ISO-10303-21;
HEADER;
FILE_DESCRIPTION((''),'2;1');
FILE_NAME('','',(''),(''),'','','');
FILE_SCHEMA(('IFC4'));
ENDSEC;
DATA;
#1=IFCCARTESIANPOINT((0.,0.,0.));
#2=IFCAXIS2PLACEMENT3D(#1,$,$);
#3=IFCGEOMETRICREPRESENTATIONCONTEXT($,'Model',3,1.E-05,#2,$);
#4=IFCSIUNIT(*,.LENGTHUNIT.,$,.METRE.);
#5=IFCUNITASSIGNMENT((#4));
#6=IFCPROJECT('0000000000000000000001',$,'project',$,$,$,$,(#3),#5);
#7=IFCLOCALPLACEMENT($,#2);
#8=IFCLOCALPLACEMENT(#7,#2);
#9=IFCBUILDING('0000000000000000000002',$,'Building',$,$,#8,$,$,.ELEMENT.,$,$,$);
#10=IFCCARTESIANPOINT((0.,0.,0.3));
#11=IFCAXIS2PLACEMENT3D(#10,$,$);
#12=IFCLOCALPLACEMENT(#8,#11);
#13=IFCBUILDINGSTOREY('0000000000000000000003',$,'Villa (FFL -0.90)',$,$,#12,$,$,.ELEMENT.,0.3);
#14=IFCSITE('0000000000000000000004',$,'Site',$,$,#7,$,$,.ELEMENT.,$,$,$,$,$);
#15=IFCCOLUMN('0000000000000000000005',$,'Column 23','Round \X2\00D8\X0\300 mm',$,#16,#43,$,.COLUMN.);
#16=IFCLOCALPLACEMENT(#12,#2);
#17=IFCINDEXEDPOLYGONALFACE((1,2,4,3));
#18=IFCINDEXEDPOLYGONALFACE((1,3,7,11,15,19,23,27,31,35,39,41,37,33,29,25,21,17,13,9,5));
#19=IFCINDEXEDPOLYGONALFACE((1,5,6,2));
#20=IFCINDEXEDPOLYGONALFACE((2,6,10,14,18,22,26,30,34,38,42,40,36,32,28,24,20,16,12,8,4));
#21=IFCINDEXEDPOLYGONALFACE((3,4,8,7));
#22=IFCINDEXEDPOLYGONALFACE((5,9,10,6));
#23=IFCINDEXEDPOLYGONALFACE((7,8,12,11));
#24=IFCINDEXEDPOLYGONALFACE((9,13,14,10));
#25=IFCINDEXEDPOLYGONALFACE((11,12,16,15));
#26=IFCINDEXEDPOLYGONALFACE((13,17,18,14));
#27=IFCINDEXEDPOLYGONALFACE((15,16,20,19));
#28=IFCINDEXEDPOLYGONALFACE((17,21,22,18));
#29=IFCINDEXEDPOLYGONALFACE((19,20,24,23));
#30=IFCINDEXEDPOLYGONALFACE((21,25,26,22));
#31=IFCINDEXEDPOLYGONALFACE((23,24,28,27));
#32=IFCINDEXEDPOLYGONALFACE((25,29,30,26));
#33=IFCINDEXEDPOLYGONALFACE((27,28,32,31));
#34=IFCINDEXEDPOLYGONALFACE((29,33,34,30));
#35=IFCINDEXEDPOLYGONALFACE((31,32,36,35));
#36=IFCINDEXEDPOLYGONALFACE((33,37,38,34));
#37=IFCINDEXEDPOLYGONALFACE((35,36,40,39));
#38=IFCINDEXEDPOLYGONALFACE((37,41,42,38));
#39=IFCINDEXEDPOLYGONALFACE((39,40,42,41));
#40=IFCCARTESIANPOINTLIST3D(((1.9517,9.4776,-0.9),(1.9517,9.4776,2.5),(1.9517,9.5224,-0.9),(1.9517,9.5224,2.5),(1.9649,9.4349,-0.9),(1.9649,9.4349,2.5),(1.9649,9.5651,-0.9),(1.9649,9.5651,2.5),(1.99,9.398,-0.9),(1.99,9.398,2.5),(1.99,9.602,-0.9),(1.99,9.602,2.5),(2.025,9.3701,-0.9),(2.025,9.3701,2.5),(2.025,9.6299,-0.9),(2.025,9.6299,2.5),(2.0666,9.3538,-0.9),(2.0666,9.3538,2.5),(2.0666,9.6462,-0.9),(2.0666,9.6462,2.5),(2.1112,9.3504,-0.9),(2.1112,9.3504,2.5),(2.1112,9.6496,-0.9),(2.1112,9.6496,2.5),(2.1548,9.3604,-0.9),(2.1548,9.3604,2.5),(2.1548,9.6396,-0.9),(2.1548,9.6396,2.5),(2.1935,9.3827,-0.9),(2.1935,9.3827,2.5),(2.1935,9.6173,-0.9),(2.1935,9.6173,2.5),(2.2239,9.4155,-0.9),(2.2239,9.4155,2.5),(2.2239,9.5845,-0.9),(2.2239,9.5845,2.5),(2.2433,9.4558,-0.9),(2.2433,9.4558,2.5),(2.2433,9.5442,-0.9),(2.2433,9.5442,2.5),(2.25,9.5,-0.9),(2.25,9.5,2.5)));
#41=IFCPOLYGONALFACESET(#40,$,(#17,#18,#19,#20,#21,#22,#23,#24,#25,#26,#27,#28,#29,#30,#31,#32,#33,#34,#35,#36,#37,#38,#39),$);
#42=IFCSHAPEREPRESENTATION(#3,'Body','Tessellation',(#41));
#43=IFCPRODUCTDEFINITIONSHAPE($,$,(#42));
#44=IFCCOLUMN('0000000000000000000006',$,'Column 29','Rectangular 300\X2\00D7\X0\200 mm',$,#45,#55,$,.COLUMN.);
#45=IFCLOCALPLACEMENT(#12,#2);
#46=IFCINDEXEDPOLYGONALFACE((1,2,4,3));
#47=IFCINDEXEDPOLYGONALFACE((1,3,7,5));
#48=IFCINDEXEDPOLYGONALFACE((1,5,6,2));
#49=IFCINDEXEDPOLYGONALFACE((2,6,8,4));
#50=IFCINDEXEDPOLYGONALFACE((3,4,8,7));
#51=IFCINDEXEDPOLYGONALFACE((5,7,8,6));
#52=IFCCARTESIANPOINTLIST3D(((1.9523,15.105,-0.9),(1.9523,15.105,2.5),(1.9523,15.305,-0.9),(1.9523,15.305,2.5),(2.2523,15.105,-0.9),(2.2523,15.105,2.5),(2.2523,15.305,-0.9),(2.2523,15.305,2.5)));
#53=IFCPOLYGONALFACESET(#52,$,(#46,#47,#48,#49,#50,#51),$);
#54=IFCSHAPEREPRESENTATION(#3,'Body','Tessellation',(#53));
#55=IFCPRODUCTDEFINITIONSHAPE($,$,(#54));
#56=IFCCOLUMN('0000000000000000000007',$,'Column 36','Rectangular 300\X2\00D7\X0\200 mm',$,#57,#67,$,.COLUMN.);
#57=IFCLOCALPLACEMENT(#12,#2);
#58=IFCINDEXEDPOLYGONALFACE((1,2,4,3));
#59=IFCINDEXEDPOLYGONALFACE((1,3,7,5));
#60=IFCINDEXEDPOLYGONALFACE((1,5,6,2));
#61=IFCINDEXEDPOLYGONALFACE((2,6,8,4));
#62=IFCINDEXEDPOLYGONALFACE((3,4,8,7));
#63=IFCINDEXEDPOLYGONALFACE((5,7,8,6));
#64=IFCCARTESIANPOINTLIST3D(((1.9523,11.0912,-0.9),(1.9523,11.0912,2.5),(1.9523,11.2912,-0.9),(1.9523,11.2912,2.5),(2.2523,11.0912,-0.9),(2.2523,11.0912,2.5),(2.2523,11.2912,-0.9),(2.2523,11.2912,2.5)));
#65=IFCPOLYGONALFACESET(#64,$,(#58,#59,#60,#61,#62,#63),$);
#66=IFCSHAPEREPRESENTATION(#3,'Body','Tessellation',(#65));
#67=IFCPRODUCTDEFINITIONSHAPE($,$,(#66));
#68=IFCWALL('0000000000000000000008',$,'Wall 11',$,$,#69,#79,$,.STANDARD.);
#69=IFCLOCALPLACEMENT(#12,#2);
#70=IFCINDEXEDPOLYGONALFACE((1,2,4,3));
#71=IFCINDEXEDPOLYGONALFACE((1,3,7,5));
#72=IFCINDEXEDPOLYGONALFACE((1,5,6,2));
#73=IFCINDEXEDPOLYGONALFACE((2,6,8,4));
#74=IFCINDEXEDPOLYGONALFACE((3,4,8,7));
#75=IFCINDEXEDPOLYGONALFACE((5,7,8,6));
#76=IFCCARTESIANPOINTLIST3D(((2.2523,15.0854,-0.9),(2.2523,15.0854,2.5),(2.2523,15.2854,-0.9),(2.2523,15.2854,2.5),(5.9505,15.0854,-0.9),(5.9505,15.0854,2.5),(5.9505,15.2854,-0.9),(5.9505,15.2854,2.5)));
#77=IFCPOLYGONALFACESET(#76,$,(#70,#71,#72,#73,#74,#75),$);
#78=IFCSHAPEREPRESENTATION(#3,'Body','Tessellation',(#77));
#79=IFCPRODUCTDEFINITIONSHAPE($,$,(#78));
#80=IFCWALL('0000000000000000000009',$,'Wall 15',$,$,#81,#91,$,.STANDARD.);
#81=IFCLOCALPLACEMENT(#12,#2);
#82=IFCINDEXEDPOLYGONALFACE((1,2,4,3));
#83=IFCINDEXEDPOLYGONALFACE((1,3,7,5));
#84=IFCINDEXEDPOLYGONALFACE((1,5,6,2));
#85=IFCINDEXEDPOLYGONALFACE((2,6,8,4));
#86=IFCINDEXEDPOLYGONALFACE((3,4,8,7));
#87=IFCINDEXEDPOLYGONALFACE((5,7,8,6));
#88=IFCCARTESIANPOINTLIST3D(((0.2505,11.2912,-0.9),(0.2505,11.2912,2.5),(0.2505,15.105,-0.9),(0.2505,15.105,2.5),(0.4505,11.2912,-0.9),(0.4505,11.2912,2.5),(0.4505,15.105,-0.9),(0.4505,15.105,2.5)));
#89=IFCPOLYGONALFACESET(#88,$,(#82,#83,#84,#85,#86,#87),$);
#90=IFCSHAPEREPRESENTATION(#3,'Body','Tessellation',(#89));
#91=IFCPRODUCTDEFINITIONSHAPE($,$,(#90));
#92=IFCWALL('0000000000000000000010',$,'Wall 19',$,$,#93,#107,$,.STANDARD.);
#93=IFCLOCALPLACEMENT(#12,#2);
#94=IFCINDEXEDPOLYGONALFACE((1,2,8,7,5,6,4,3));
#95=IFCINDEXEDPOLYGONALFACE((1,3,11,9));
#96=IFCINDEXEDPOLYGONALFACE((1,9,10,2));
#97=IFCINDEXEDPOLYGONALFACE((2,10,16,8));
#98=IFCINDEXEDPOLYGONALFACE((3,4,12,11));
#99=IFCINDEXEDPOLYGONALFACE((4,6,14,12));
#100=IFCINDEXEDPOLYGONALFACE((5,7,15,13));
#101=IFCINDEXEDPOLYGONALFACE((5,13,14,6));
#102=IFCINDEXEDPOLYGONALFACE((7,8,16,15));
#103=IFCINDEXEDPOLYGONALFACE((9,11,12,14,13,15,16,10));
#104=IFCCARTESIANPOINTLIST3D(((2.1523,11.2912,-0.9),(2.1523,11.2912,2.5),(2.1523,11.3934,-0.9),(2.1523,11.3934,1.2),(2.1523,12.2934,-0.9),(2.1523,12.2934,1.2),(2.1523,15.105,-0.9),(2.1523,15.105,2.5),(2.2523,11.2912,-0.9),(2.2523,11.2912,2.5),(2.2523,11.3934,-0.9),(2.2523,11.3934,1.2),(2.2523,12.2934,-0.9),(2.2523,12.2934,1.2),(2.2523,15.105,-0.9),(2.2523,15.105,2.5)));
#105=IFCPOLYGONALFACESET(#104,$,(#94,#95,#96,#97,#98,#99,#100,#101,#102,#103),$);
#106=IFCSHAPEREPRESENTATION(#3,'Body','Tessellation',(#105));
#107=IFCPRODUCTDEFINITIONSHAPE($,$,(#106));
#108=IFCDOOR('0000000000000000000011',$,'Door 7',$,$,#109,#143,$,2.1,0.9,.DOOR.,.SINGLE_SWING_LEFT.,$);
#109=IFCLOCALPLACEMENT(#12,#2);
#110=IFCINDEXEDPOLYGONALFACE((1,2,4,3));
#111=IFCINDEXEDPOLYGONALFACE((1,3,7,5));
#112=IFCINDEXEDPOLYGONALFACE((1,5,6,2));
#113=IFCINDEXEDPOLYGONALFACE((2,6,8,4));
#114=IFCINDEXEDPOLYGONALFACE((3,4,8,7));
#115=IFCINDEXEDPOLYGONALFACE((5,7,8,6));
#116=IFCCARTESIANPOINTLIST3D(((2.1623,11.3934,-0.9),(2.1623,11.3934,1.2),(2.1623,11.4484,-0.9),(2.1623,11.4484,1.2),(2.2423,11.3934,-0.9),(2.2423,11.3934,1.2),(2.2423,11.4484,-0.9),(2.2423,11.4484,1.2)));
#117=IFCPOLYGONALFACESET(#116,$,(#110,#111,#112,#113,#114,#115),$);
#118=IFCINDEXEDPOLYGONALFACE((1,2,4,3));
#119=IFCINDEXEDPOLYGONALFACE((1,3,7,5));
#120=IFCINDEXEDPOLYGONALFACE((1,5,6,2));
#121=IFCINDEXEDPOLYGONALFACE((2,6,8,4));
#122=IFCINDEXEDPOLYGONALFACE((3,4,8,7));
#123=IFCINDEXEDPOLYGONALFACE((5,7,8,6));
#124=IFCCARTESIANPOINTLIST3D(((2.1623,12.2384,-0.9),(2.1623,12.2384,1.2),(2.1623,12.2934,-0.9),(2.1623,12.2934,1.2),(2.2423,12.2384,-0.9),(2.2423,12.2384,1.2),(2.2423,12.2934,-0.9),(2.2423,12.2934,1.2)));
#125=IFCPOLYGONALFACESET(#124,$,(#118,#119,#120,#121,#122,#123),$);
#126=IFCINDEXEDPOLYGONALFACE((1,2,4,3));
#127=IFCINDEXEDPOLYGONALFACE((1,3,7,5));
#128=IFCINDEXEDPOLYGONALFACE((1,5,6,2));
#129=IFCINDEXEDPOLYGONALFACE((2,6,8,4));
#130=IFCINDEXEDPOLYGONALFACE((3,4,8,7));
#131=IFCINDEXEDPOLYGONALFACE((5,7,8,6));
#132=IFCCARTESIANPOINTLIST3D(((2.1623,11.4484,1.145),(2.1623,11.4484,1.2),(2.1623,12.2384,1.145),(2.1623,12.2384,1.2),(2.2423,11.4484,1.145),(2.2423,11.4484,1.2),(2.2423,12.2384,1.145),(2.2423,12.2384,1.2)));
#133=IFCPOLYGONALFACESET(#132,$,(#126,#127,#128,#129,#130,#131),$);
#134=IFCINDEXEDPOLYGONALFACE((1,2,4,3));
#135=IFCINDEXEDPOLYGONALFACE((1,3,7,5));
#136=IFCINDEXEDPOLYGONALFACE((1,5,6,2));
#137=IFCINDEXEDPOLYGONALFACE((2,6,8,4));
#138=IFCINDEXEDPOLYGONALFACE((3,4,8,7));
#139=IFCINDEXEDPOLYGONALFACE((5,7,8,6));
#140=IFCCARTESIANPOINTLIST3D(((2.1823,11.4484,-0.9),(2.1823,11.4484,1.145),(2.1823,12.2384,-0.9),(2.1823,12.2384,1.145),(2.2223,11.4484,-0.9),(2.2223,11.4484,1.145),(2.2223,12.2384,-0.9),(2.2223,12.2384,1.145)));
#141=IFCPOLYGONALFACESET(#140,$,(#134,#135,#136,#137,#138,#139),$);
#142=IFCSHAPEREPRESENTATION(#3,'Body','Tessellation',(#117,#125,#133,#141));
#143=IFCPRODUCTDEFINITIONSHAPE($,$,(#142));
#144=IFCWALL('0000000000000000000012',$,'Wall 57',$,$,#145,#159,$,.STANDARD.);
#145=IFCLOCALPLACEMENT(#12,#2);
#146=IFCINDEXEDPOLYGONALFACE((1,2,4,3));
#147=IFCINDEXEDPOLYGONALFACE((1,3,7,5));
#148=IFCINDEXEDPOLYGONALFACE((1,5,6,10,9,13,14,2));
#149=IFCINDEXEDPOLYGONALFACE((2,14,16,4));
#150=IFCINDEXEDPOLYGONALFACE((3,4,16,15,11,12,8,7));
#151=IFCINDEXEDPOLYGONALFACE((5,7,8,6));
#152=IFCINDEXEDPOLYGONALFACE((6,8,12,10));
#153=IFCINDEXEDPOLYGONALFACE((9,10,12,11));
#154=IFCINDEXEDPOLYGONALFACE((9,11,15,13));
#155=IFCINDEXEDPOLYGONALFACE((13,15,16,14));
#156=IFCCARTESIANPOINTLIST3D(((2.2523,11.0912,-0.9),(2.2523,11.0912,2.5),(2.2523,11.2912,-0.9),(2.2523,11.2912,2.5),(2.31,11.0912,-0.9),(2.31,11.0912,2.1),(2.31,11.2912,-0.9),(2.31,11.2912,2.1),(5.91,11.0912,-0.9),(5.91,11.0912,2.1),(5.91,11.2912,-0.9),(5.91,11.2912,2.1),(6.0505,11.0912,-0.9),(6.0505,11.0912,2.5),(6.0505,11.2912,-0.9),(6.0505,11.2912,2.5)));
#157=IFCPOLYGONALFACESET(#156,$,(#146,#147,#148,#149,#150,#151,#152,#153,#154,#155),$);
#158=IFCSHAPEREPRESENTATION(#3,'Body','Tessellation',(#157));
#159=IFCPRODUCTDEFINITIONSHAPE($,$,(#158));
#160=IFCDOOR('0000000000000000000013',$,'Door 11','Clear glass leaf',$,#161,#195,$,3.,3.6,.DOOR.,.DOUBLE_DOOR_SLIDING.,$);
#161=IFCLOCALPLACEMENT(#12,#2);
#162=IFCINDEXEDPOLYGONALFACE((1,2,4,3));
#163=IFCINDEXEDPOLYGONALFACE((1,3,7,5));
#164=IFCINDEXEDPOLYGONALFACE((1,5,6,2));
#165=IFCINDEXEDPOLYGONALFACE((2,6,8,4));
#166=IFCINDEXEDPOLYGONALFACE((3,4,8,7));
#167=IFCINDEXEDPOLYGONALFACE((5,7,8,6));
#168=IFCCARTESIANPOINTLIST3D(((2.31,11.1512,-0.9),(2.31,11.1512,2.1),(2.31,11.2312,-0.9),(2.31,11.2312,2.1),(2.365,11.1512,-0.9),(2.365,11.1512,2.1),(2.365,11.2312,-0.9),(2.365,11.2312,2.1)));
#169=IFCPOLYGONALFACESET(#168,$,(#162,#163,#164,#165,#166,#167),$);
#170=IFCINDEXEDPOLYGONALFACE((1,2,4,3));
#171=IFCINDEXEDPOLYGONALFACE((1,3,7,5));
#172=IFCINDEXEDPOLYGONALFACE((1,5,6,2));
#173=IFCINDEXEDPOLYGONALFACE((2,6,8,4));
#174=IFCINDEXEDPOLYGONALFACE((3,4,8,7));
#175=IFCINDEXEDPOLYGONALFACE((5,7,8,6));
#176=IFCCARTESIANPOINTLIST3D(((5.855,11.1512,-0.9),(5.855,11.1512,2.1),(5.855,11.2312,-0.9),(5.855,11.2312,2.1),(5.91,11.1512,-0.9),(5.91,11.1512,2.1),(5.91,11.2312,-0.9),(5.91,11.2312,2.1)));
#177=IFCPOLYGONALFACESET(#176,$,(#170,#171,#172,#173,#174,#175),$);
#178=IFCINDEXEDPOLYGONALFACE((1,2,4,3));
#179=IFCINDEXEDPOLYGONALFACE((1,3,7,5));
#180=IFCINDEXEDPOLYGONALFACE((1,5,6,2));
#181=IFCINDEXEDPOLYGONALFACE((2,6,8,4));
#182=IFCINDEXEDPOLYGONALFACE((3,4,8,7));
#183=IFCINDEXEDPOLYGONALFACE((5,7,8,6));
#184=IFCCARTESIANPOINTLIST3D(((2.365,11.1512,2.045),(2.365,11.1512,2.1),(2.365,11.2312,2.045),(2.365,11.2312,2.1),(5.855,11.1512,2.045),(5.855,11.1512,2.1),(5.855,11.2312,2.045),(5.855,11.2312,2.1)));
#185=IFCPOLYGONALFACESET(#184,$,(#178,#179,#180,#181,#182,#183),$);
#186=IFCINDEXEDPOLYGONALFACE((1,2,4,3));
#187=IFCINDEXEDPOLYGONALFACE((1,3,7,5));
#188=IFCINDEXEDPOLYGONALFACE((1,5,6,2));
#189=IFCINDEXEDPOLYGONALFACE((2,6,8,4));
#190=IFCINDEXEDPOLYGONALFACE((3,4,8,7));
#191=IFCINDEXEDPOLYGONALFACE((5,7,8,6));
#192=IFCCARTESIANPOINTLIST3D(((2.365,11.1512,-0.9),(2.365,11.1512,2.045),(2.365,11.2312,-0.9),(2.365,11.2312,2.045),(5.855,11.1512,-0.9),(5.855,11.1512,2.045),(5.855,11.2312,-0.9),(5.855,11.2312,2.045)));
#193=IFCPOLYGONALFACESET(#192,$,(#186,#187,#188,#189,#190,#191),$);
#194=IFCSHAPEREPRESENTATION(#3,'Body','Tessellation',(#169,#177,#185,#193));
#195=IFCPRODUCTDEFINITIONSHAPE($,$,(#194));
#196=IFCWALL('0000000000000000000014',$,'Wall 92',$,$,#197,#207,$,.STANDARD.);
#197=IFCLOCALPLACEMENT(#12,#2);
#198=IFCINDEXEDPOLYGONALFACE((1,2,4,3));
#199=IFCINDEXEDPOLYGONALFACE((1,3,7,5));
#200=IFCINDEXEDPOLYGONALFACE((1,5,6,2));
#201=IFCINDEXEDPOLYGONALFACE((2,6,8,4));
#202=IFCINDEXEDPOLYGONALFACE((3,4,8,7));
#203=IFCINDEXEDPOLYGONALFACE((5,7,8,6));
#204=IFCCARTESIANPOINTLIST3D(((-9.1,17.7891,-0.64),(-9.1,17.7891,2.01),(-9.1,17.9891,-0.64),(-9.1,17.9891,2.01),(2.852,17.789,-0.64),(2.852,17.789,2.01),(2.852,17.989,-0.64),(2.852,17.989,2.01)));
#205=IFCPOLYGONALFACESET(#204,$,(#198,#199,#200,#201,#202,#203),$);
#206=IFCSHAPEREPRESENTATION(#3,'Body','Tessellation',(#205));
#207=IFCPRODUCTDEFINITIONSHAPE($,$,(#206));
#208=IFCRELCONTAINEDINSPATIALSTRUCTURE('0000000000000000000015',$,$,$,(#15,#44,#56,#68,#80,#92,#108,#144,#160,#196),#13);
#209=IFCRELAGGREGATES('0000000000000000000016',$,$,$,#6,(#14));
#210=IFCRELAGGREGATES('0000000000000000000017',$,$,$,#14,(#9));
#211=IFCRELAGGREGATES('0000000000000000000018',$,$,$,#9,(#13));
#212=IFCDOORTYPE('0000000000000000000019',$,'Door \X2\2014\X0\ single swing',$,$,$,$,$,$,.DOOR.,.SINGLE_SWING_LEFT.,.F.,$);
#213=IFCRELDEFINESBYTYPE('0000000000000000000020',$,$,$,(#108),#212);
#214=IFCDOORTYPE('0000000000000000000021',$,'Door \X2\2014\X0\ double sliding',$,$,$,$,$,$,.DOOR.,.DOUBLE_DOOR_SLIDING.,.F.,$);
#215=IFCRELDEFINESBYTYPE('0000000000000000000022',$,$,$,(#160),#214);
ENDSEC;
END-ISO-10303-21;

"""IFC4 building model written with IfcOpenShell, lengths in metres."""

from ifc_helpers import new_model, si_unit, frame, frame_2d, origin, origin_2d, place, context, project, spatial, polyline, rectangle, circle, outline, extrude, type_object, element, fill, save


model = new_model("IFC4")

# Units and contexts
model_context = context("Model", 3, precision=1e-05, world=origin())
ifc_project = project(units=[si_unit("LENGTHUNIT", "METRE")], contexts=[model_context])

# Site, building, storey
site_placement = place(None, origin())
site = spatial("IfcSite", under=ifc_project, at=site_placement, Name="Site", CompositionType="ELEMENT")
building_placement = place(site_placement, origin())
building = spatial("IfcBuilding", under=site, at=building_placement, Name="Building", CompositionType="ELEMENT")
storey_placement = place(building_placement, frame((0.0, 0.0, 0.3)))
storey = spatial("IfcBuildingStorey", under=building, at=storey_placement, Name="Villa (FFL -0.90)", CompositionType="ELEMENT", Elevation=0.3)

# Columns
column_placement = place(storey_placement, frame((2.1, 9.5, -0.9), z_axis=(0.0, 0.0, 1.0), x_axis=(1.0, 0.0, 0.0)))
element("IfcColumn", 1, at=column_placement, inside=storey, Name="Column 23", Description="Round Ø300 mm", PredefinedType="COLUMN", context=model_context, shape_type="SweptSolid", body=[
    extrude(circle(Radius=0.15, at=origin_2d()), origin(), (0.0, 0.0, 1.0), 3.4),
])
for number, where, z_axis, x_axis, name in (
    (2, (2.1023, 15.205, -0.9), (0.0, 0.0, 1.0), (1.0, 0.0, 0.0), "Column 29"),
    (3, (2.1023, 11.1912, -0.9), (0.0, 0.0, 1.0), (1.0, 0.0, 0.0), "Column 36"),
):
    element("IfcColumn", number, at=place(storey_placement, frame(where, z_axis=z_axis, x_axis=x_axis)), inside=storey, Name=name, Description="Rectangular 300×200 mm", PredefinedType="COLUMN", context=model_context, shape_type="SweptSolid", body=[
        extrude(outline(polyline([(-0.15, -0.1), (0.15, -0.1), (0.15, 0.1), (-0.15, 0.1), (-0.15, -0.1)])), origin(), (0.0, 0.0, 1.0), 3.4),
    ])

# Walls
wall_1_placement = place(storey_placement, frame((2.2523, 15.1854, -0.9), z_axis=(0.0, 0.0, 1.0), x_axis=(1.0, 0.0, 0.0)))
element("IfcWall", 4, at=wall_1_placement, inside=storey, Name="Wall 11", PredefinedType="STANDARD", context=model_context, shape_type="SweptSolid", body=[
    extrude(rectangle(XDim=3.6982, YDim=0.2, at=frame_2d((1.8491, 0.0))), origin(), (0.0, 0.0, 1.0), 3.4),
])
wall_2_placement = place(storey_placement, frame((0.3505, 11.2912, -0.9), z_axis=(0.0, 0.0, 1.0), x_axis=(0.0, 1.0, 0.0)))
element("IfcWall", 5, at=wall_2_placement, inside=storey, Name="Wall 15", PredefinedType="STANDARD", context=model_context, shape_type="SweptSolid", body=[
    extrude(rectangle(XDim=3.8138, YDim=0.2, at=frame_2d((1.9069, 0.0))), origin(), (0.0, 0.0, 1.0), 3.4),
])

# Walls, openings, doors
wall_3_placement = place(storey_placement, frame((2.2023, 11.2912, -0.9), z_axis=(0.0, 0.0, 1.0), x_axis=(0.0, 1.0, 0.0)))
wall_3 = element("IfcWall", 6, at=wall_3_placement, inside=storey, Name="Wall 19", PredefinedType="STANDARD", context=model_context, shape_type="SweptSolid", body=[
    extrude(rectangle(XDim=3.8138, YDim=0.1, at=frame_2d((1.9069, 0.0))), origin(), (0.0, 0.0, 1.0), 3.4),
])
opening_1_placement = place(storey_placement, frame((2.2023, 11.3934, -0.9), z_axis=(0.0, 0.0, 1.0), x_axis=(0.0, 1.0, 0.0)))
opening_1 = element("IfcOpeningElement", 7, at=opening_1_placement, cuts=wall_3, PredefinedType="OPENING", context=model_context, shape_type="SweptSolid", body=[
    extrude(rectangle(XDim=0.9, YDim=0.16, at=frame_2d((0.45, 0.0))), origin(), (0.0, 0.0, 1.0), 2.1),
])
door_type_1 = type_object("IfcDoorType", Name="Door — single swing", OperationType="SINGLE_SWING_LEFT", ParameterTakesPrecedence=False, PredefinedType="DOOR")
door_1_placement = place(storey_placement, frame((2.2023, 11.3934, -0.9), z_axis=(0.0, 0.0, 1.0), x_axis=(0.0, 1.0, 0.0)))
door_1 = element("IfcDoor", 8, at=door_1_placement, inside=storey, type_object=door_type_1, Name="Door 7", OperationType="SINGLE_SWING_LEFT", OverallHeight=2.1, OverallWidth=0.9, PredefinedType="DOOR", context=model_context, shape_type="SweptSolid", body=[
    extrude(rectangle(XDim=0.055, YDim=0.08, at=frame_2d((0.0275, 0.0))), origin(), (0.0, 0.0, 1.0), 2.1),
    extrude(rectangle(XDim=0.055, YDim=0.08, at=frame_2d((0.8725, 0.0))), origin(), (0.0, 0.0, 1.0), 2.1),
    extrude(rectangle(XDim=0.79, YDim=0.08, at=frame_2d((0.45, 0.0))), frame((0.0, 0.0, 2.045)), (0.0, 0.0, 1.0), 0.055),
    extrude(rectangle(XDim=0.79, YDim=0.04, at=frame_2d((0.45, 0.0))), origin(), (0.0, 0.0, 1.0), 2.045),
])
fill(opening_1, door_1)
wall_4_placement = place(storey_placement, frame((2.2523, 11.1912, -0.9), z_axis=(0.0, 0.0, 1.0), x_axis=(1.0, 0.0, 0.0)))
wall_4 = element("IfcWall", 9, at=wall_4_placement, inside=storey, Name="Wall 57", PredefinedType="STANDARD", context=model_context, shape_type="SweptSolid", body=[
    extrude(rectangle(XDim=3.7982, YDim=0.2, at=frame_2d((1.8991, 0.0))), origin(), (0.0, 0.0, 1.0), 3.4),
])
opening_2_placement = place(storey_placement, frame((2.31, 11.1912, -0.9), z_axis=(0.0, 0.0, 1.0), x_axis=(1.0, 0.0, 0.0)))
opening_2 = element("IfcOpeningElement", 10, at=opening_2_placement, cuts=wall_4, PredefinedType="OPENING", context=model_context, shape_type="SweptSolid", body=[
    extrude(rectangle(XDim=3.6, YDim=0.26, at=frame_2d((1.8, 0.0))), origin(), (0.0, 0.0, 1.0), 3.0),
])
door_type_2 = type_object("IfcDoorType", Name="Door — double sliding", OperationType="DOUBLE_DOOR_SLIDING", ParameterTakesPrecedence=False, PredefinedType="DOOR")
door_2_placement = place(storey_placement, frame((2.31, 11.1912, -0.9), z_axis=(0.0, 0.0, 1.0), x_axis=(1.0, 0.0, 0.0)))
door_2 = element("IfcDoor", 11, at=door_2_placement, inside=storey, type_object=door_type_2, Name="Door 11", Description="Clear glass leaf", OperationType="DOUBLE_DOOR_SLIDING", OverallHeight=3.0, OverallWidth=3.6, PredefinedType="DOOR", context=model_context, shape_type="SweptSolid", body=[
    extrude(rectangle(XDim=0.055, YDim=0.08, at=frame_2d((0.0275, 0.0))), origin(), (0.0, 0.0, 1.0), 3.0),
    extrude(rectangle(XDim=0.055, YDim=0.08, at=frame_2d((3.5725, 0.0))), origin(), (0.0, 0.0, 1.0), 3.0),
    extrude(rectangle(XDim=3.49, YDim=0.08, at=frame_2d((1.8, 0.0))), frame((0.0, 0.0, 2.945)), (0.0, 0.0, 1.0), 0.055),
    extrude(rectangle(XDim=3.49, YDim=0.08, at=frame_2d((1.8, 0.0))), origin(), (0.0, 0.0, 1.0), 2.945),
])
fill(opening_2, door_2)

# Wall
wall_5_placement = place(storey_placement, frame((2.852, 17.889, -0.64), z_axis=(0.0, 0.0, 1.0), x_axis=(-1.0, 0.000008, 0.0)))
element("IfcWall", 12, at=wall_5_placement, inside=storey, Name="Wall 92", PredefinedType="STANDARD", context=model_context, shape_type="SweptSolid", body=[
    extrude(rectangle(XDim=11.952, YDim=0.2, at=frame_2d((5.976, 0.0))), origin(), (0.0, 0.0, 1.0), 2.65),
])

save(model, "model.ifc")
